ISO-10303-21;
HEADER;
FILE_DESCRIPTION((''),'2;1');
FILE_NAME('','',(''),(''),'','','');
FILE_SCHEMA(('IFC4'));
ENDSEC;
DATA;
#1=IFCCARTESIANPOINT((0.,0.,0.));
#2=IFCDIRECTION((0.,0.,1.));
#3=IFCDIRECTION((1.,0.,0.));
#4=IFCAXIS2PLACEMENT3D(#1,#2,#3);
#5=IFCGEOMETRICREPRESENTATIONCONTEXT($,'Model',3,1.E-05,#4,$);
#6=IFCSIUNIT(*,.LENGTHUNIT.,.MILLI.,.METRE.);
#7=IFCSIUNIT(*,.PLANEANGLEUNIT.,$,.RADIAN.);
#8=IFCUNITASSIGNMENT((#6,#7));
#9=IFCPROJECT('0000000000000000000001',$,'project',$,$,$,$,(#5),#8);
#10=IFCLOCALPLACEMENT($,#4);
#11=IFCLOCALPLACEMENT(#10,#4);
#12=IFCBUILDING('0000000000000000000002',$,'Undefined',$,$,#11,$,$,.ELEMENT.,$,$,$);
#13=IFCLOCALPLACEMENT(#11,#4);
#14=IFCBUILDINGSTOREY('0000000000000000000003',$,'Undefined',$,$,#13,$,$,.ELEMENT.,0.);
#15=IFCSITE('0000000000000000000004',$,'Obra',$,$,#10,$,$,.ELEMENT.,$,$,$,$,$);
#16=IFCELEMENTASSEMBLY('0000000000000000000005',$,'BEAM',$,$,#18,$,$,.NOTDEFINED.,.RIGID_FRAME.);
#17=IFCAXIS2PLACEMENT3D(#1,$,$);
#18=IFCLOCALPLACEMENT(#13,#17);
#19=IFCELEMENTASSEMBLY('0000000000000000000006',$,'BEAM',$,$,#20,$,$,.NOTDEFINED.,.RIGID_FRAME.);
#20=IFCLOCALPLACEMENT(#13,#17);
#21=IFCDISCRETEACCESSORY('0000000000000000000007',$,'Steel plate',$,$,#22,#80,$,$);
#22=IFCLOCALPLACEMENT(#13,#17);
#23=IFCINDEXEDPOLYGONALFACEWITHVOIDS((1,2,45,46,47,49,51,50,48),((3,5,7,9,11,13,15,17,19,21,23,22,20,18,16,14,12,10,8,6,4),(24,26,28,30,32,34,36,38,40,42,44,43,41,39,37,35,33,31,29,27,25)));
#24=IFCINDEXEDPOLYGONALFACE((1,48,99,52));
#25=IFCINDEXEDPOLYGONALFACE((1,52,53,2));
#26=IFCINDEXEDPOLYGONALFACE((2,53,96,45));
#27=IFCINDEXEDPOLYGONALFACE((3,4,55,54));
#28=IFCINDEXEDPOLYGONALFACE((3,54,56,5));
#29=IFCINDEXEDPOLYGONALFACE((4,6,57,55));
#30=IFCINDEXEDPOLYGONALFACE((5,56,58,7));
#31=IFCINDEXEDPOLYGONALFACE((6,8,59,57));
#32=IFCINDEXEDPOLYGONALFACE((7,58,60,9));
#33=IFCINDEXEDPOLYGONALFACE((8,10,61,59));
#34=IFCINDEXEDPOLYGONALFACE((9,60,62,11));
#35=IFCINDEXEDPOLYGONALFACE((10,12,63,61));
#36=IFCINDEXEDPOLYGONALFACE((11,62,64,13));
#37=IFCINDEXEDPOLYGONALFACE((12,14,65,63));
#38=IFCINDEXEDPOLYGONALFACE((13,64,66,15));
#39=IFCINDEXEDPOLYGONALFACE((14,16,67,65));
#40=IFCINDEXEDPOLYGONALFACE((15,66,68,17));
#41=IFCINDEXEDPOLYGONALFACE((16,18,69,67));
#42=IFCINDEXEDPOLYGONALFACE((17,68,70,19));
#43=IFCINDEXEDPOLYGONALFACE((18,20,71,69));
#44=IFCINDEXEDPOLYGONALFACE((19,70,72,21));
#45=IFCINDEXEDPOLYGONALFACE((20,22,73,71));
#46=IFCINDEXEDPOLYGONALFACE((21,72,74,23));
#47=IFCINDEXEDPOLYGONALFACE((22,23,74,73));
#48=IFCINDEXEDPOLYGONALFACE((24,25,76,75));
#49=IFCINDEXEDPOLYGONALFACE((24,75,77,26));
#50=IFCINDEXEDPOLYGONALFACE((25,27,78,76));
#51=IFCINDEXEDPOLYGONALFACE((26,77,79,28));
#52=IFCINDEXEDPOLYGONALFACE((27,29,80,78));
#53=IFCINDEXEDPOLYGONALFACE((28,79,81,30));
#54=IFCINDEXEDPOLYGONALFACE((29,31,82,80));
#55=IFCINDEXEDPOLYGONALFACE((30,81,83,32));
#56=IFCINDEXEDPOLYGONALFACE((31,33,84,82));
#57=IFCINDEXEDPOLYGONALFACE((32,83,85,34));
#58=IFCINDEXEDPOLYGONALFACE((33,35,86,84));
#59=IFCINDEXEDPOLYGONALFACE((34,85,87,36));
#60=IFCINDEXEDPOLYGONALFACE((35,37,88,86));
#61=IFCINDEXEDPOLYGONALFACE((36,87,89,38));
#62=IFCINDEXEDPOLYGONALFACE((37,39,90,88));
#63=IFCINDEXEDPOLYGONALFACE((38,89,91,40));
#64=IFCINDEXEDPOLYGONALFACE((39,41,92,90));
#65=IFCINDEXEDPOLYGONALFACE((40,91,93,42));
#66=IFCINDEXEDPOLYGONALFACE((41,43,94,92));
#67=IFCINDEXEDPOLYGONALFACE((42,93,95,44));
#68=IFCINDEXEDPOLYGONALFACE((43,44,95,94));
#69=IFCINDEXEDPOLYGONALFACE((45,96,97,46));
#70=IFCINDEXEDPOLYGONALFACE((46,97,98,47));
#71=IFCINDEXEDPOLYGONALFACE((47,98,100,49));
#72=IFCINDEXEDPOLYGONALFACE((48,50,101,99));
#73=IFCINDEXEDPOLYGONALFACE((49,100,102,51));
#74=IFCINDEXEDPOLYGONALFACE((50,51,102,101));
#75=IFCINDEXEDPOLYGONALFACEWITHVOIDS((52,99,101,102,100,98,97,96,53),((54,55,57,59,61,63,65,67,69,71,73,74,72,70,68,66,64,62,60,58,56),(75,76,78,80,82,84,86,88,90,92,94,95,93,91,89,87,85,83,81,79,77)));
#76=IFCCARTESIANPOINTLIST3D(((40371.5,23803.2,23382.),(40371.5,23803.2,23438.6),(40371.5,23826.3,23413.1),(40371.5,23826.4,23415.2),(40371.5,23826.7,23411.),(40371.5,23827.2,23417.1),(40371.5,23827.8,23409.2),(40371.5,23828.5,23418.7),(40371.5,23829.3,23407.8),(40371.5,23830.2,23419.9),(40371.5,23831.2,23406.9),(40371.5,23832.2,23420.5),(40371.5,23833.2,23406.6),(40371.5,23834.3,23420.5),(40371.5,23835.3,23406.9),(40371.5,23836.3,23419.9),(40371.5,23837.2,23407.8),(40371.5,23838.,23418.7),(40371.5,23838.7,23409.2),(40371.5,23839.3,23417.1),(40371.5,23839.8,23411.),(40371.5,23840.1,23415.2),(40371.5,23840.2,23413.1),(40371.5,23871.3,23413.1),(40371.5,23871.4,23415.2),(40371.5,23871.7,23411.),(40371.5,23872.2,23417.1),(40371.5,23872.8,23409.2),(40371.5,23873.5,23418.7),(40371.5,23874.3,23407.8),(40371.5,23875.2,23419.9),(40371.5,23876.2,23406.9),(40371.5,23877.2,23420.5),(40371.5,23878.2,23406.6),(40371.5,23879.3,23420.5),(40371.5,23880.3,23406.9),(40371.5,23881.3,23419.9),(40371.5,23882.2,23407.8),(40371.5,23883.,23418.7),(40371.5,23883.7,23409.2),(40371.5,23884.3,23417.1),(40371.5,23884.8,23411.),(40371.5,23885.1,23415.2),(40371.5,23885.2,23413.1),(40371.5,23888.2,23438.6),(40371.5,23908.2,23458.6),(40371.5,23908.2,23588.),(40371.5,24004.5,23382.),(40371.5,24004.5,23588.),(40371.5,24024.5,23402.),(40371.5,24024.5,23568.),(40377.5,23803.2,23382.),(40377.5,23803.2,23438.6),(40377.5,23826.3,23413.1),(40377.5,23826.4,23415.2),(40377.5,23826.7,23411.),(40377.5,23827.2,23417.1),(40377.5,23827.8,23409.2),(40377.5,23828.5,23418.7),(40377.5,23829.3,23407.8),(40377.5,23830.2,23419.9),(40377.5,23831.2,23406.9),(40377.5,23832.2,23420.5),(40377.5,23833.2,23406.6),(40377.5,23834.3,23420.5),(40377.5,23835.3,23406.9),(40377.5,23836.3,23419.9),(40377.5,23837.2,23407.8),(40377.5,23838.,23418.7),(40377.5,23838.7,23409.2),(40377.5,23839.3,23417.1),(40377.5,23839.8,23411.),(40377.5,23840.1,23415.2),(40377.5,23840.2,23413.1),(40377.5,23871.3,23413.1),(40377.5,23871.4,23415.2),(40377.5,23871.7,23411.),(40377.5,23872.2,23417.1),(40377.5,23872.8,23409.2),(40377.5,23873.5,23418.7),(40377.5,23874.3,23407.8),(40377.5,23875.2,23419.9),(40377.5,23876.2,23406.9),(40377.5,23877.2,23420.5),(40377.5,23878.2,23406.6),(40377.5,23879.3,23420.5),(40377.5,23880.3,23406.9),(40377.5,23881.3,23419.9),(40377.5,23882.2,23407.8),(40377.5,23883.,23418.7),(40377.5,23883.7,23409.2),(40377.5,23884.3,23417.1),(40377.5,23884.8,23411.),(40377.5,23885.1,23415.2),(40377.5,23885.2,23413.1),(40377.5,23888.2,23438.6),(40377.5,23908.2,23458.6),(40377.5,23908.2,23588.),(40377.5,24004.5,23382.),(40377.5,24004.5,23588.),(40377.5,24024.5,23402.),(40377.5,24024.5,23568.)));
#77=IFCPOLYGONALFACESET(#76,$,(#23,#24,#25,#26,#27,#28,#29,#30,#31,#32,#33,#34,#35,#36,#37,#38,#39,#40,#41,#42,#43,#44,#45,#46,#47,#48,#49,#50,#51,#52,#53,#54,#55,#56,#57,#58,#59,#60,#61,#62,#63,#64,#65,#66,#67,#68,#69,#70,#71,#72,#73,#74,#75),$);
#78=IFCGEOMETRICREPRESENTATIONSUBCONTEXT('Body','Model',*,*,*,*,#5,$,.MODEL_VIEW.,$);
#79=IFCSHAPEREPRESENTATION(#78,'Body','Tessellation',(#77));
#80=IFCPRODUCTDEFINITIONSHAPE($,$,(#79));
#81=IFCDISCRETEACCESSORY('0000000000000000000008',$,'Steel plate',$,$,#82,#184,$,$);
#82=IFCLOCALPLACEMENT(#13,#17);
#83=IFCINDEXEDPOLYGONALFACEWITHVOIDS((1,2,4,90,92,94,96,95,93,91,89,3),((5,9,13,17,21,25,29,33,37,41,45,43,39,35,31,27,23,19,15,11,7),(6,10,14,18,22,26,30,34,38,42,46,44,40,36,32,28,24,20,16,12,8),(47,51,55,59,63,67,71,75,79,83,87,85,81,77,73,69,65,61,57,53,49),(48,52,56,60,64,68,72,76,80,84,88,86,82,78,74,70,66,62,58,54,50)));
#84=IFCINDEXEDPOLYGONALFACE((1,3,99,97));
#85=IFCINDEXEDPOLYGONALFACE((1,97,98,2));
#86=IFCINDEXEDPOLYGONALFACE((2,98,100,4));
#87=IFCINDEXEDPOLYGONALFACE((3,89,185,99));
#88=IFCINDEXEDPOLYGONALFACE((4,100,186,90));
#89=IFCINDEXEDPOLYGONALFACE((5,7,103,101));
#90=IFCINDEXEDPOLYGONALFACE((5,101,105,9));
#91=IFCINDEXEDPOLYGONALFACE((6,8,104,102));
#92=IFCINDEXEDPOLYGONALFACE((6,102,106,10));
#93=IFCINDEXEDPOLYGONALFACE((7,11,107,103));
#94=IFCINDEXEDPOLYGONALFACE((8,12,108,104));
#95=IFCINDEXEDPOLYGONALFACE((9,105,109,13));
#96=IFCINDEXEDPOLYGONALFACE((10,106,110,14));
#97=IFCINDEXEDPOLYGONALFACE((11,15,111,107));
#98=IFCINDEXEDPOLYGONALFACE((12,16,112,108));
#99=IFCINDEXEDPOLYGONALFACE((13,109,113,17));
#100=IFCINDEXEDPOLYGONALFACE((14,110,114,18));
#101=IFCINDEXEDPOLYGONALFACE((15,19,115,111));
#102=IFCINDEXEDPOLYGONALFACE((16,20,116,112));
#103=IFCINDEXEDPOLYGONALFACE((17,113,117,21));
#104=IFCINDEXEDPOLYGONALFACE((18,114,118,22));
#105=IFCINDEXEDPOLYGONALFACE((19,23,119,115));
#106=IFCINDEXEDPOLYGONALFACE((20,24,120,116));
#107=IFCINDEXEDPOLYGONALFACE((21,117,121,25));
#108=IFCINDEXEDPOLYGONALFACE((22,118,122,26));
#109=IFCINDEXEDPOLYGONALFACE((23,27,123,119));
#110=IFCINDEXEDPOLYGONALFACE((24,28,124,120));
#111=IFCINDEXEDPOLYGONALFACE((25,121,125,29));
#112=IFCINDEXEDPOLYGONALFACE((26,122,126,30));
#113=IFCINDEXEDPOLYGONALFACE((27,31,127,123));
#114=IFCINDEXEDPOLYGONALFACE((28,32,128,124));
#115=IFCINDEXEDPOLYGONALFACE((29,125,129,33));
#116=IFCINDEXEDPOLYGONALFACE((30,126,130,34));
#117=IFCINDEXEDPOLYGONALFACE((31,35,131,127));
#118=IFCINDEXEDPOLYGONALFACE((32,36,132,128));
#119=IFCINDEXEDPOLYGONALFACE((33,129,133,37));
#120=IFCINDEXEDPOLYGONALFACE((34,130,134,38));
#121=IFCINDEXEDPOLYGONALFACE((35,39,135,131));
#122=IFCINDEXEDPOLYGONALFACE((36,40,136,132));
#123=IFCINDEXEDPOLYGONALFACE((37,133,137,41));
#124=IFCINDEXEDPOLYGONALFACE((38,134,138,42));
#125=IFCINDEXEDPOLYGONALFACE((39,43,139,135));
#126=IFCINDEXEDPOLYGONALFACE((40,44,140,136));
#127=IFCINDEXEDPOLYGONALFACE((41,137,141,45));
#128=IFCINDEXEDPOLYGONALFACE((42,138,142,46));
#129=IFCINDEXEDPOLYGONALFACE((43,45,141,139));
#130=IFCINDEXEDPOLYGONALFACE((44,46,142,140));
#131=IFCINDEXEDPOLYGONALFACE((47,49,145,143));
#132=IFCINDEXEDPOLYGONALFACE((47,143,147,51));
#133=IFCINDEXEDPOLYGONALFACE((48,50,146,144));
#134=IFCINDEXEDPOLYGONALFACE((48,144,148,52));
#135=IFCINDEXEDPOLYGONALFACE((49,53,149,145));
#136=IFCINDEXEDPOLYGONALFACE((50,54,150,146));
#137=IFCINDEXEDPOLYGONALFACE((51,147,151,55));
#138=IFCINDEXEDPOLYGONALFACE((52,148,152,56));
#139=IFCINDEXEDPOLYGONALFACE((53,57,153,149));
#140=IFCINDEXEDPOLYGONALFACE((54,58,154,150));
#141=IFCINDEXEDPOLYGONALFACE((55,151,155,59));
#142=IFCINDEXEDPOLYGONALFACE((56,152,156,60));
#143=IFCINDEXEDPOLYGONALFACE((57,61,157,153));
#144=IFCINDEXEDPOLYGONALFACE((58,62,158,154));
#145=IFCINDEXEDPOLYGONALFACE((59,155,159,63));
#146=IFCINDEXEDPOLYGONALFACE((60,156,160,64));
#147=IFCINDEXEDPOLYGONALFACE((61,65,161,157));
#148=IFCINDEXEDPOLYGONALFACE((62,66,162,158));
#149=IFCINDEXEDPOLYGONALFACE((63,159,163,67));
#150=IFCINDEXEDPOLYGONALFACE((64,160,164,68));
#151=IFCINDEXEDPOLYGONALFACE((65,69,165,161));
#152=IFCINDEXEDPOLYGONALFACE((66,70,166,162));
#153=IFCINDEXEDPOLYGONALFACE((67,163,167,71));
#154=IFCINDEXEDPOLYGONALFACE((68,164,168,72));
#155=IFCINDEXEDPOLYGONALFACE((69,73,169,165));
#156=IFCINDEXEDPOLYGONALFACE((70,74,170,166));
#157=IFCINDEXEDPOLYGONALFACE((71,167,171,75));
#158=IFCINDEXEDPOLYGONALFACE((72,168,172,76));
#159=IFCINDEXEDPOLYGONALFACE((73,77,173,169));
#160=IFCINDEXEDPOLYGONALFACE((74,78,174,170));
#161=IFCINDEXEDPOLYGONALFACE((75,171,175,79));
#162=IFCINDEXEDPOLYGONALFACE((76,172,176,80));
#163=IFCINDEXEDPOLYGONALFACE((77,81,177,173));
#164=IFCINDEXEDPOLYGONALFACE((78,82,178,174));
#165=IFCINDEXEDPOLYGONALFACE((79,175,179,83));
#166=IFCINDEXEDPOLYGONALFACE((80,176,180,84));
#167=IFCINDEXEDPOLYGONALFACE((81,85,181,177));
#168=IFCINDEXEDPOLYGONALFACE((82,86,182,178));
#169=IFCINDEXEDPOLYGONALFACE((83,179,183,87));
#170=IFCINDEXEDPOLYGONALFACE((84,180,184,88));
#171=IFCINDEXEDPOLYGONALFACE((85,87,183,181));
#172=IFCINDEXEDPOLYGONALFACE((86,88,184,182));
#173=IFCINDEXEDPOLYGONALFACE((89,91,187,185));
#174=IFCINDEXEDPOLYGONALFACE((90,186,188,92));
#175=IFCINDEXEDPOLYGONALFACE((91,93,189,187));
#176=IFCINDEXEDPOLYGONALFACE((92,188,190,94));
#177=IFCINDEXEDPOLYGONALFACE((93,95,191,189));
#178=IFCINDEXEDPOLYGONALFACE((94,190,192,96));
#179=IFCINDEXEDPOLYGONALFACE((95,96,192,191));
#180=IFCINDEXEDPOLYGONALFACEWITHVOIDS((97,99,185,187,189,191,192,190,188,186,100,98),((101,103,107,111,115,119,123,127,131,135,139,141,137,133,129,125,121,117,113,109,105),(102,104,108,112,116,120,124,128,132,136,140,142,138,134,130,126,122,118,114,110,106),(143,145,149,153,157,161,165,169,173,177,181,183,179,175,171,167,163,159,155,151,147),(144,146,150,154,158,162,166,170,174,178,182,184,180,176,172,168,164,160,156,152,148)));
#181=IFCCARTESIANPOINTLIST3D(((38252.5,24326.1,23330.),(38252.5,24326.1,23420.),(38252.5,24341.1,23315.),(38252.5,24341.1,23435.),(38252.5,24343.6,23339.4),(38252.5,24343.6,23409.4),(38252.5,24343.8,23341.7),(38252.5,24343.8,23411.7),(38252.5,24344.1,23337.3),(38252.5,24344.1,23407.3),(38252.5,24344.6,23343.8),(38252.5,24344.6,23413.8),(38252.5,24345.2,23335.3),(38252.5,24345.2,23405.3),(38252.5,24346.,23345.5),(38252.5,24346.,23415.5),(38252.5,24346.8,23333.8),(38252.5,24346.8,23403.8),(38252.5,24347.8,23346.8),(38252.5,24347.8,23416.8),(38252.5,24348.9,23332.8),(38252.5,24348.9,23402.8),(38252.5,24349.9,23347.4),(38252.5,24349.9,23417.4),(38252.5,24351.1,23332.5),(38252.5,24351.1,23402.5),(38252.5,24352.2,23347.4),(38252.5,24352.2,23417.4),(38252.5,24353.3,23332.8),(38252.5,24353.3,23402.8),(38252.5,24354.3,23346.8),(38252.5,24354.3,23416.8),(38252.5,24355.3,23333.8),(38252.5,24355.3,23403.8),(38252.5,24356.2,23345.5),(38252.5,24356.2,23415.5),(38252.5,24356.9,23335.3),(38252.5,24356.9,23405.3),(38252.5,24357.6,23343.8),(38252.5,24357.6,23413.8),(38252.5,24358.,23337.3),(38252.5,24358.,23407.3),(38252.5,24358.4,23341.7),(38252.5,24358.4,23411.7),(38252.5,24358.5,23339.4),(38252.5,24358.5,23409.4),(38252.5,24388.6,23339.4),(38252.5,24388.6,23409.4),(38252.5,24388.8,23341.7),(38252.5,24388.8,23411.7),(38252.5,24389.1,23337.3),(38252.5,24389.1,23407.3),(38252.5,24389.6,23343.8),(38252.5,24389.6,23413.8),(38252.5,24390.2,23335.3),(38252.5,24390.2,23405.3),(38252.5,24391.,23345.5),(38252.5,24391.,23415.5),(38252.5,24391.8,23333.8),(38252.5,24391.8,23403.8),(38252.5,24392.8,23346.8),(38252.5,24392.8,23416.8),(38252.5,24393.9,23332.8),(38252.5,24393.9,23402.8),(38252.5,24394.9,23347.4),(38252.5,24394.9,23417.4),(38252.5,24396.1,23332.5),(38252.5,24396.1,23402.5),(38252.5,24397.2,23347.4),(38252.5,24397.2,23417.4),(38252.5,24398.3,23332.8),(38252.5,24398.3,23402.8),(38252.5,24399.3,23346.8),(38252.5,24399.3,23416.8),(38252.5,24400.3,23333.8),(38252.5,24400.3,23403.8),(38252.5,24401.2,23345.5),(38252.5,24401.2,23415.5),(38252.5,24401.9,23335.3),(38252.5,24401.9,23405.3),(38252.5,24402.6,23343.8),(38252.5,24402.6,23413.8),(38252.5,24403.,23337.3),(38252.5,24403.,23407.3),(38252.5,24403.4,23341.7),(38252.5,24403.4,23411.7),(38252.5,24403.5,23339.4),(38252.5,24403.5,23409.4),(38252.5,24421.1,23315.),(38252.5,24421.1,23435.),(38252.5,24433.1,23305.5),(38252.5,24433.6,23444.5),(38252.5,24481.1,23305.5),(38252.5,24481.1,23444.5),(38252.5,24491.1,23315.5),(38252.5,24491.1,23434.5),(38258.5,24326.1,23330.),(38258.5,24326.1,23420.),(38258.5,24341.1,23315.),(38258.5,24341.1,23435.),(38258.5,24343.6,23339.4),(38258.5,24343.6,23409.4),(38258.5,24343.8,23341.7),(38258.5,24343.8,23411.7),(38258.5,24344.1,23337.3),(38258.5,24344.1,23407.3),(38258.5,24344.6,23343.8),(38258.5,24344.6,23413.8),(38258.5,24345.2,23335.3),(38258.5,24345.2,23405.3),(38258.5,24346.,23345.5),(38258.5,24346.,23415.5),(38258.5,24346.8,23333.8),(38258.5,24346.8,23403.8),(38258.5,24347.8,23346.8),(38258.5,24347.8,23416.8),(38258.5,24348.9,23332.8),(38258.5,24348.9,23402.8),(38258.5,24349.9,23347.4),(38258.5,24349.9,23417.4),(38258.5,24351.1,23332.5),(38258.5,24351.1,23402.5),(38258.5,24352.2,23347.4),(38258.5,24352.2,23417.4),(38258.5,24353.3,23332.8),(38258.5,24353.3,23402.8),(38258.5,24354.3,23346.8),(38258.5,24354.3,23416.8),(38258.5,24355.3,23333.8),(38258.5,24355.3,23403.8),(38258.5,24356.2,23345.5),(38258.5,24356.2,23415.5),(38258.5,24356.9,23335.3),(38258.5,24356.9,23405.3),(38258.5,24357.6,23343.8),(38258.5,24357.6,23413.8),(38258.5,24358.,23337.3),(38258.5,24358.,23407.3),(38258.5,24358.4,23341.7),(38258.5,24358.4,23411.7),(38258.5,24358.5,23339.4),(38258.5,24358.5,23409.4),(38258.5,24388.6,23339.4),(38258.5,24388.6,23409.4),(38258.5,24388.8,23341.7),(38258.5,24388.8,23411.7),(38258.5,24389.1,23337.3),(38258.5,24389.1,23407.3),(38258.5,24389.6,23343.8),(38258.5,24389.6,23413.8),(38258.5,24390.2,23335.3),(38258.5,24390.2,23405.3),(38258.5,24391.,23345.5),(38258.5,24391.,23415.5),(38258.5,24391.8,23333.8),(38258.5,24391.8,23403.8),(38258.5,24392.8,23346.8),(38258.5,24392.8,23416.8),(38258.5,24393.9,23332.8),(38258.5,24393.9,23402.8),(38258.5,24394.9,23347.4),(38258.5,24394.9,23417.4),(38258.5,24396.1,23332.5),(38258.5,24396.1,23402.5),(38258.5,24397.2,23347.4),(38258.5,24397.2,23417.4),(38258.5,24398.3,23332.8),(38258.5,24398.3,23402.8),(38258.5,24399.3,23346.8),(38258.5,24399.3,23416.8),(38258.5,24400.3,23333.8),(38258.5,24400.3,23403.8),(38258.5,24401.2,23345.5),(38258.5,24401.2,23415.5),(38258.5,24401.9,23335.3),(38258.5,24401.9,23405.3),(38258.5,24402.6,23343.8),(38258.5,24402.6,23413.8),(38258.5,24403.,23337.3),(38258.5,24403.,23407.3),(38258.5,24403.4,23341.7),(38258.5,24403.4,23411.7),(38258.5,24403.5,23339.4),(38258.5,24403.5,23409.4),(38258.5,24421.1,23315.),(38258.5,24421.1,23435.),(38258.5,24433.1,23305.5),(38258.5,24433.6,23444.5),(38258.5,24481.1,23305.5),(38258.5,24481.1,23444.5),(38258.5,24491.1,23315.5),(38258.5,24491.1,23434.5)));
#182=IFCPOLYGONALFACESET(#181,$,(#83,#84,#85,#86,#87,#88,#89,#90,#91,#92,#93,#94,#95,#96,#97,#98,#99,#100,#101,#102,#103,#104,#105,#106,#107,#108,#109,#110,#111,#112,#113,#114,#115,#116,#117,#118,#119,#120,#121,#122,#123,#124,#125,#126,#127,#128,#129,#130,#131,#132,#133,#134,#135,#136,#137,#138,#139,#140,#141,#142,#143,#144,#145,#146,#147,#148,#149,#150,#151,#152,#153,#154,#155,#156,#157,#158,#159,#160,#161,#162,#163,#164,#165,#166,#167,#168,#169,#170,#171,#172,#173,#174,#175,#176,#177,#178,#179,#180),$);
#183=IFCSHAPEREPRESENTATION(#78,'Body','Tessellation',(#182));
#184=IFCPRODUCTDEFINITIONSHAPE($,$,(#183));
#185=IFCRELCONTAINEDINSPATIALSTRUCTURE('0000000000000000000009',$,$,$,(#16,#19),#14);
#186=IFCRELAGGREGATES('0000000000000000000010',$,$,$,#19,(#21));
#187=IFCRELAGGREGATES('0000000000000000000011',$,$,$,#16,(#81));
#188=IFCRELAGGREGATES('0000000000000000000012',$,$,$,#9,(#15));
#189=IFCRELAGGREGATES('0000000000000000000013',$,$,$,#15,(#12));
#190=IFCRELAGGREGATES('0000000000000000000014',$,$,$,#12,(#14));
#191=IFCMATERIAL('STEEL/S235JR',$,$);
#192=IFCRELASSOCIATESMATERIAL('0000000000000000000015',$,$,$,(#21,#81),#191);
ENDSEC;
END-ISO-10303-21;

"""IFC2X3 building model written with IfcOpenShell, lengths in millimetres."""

from ifc_helpers import new_model, si_unit, frame, origin_with_axes, origin_2d_with_axis, place, context, subcontext, project, spatial, polyline, circle, outline, extrude, source, transform, mapped, material, element, aggregate, save


model = new_model("IFC2X3")

# Units and contexts
model_context = context("Model", 3, precision=1e-05, world=origin_with_axes())
body_context = subcontext(model_context, "Body", "Model", "MODEL_VIEW")
ifc_project = project(units=[si_unit("LENGTHUNIT", "METRE", prefix="MILLI"), si_unit("PLANEANGLEUNIT", "RADIAN")], contexts=[model_context])

# Site, building, storey
site_placement = place(None, origin_with_axes())
site = spatial("IfcSite", under=ifc_project, at=site_placement, Name="Obra", CompositionType="ELEMENT")
building_placement = place(site_placement, origin_with_axes())
building = spatial("IfcBuilding", under=site, at=building_placement, Name="Undefined", CompositionType="ELEMENT")
storey_placement = place(building_placement, origin_with_axes())
storey = spatial("IfcBuildingStorey", under=building, at=storey_placement, Name="Undefined", CompositionType="ELEMENT", Elevation=0.0)

# Element assembly
assembly_1_placement = place(storey_placement, origin_with_axes())
assembly_1 = element("IfcElementAssembly", 1, at=assembly_1_placement, inside=storey, Name="BEAM", AssemblyPlace="NOTDEFINED", PredefinedType="RIGID_FRAME")

# Shared definitions
ifc_material_1 = material(Name="STEEL/S235JR")

# Shared definitions
shared_shape_1 = source(origin_with_axes(), body_context, "Body", "SweptSolid", [
    extrude(circle(Radius=7.5, at=origin_2d_with_axis()), frame((0.0, 2.4, 0.0), z_axis=(0.0, 1.0, 0.0), x_axis=(1.0, 0.0, 0.0)), (0.0, 0.0, 1.0), 6.2),
])

# Element assembly, discrete accessory, opening
assembly_2_placement = place(storey_placement, origin_with_axes())
assembly_2 = element("IfcElementAssembly", 2, at=assembly_2_placement, inside=storey, Name="BEAM", AssemblyPlace="NOTDEFINED", PredefinedType="RIGID_FRAME")
discrete_accessory_1_placement = place(assembly_2_placement, frame((40374.5, 24024.5, 23402.0), z_axis=(-1.0, 0.0, 0.0), x_axis=(0.000001, -0.707107, -0.707107)))
discrete_accessory_1 = element("IfcDiscreteAccessory", 3, at=discrete_accessory_1_placement, material=ifc_material_1, Name="Steel plate", context=body_context, shape_type="SweptSolid", body=[
    extrude(outline(polyline([(0.0, 0.0), (28.3, 0.0), (170.6, 142.3), (130.6, 182.3), (70.5, 122.2), (42.2, 122.2), (-49.3, 213.7), (-117.4, 145.7), (-117.4, 117.4), (0.0, 0.0)])), frame((0.0, 0.0, -3.0), z_axis=(0.0, 0.0, 1.0), x_axis=(1.0, 0.0, 0.0)), (0.0, 0.0, 1.0), 6.0),
])
shared_shape_2 = source(origin_with_axes(), body_context, "Body", "SweptSolid", [
    extrude(circle(Radius=7.0, at=origin_2d_with_axis()), frame((0.0, -8.6, 0.0), z_axis=(0.0, 1.0, 0.0), x_axis=(1.0, 0.0, 0.0)), (0.0, 0.0, 1.0), 6.2),
])
opening_1_placement = place(assembly_2_placement, frame((40380.0, 23903.2, 23438.6), z_axis=(0.0, -1.0, 0.0), x_axis=(0.0, 0.0, -1.0)))
element("IfcOpeningElement", 4, at=opening_1_placement, cuts=discrete_accessory_1, ObjectType="Opening", context=body_context, shape_type="MappedRepresentation", body=[
    mapped(shared_shape_2, transform((25.0, 0.0, 25.0))),
    mapped(shared_shape_2, transform((25.0, 0.0, 70.0))),
    mapped(shared_shape_2, transform((95.0, 0.0, 25.0))),
    mapped(shared_shape_2, transform((95.0, 0.0, 70.0))),
])
aggregate(assembly_2, [discrete_accessory_1])

# Discrete accessory, opening
discrete_accessory_2_placement = place(assembly_1_placement, frame((38255.5, 24491.1, 23315.5), z_axis=(-1.0, 0.0, 0.0), x_axis=(0.000001, -0.707107, -0.707107)))
discrete_accessory_2 = element("IfcDiscreteAccessory", 5, at=discrete_accessory_2_placement, material=ifc_material_1, Name="Steel plate", context=body_context, shape_type="SweptSolid", body=[
    extrude(outline(polyline([(0.0, 0.0), (14.1, 0.0), (48.1, 33.9), (49.9, 49.1), (106.4, 105.7), (106.4, 126.9), (42.8, 190.6), (21.6, 190.6), (-35.0, 134.0), (-50.6, 131.9), (-84.1, 98.3), (-84.1, 84.1), (0.0, 0.0)])), frame((0.0, 0.0, -3.0), z_axis=(0.0, 0.0, 1.0), x_axis=(1.0, 0.0, 0.0)), (0.0, 0.0, 1.0), 6.0),
])
opening_2_placement = place(assembly_1_placement, frame((38250.0, 24373.6, 23410.0), z_axis=(0.0, -1.0, 0.0), x_axis=(0.0, 0.0, -1.0)))
element("IfcOpeningElement", 6, at=opening_2_placement, cuts=discrete_accessory_2, ObjectType="Opening", context=body_context, shape_type="MappedRepresentation", body=[
    mapped(shared_shape_1, transform((0.0, 0.0, -22.5))),
    mapped(shared_shape_1, transform((70.0, 0.0, -22.5))),
    mapped(shared_shape_1, transform((0.0, 0.0, 22.5))),
    mapped(shared_shape_1, transform((70.0, 0.0, 22.5))),
])

aggregate(assembly_1, [discrete_accessory_2])

save(model, "model.ifc")
